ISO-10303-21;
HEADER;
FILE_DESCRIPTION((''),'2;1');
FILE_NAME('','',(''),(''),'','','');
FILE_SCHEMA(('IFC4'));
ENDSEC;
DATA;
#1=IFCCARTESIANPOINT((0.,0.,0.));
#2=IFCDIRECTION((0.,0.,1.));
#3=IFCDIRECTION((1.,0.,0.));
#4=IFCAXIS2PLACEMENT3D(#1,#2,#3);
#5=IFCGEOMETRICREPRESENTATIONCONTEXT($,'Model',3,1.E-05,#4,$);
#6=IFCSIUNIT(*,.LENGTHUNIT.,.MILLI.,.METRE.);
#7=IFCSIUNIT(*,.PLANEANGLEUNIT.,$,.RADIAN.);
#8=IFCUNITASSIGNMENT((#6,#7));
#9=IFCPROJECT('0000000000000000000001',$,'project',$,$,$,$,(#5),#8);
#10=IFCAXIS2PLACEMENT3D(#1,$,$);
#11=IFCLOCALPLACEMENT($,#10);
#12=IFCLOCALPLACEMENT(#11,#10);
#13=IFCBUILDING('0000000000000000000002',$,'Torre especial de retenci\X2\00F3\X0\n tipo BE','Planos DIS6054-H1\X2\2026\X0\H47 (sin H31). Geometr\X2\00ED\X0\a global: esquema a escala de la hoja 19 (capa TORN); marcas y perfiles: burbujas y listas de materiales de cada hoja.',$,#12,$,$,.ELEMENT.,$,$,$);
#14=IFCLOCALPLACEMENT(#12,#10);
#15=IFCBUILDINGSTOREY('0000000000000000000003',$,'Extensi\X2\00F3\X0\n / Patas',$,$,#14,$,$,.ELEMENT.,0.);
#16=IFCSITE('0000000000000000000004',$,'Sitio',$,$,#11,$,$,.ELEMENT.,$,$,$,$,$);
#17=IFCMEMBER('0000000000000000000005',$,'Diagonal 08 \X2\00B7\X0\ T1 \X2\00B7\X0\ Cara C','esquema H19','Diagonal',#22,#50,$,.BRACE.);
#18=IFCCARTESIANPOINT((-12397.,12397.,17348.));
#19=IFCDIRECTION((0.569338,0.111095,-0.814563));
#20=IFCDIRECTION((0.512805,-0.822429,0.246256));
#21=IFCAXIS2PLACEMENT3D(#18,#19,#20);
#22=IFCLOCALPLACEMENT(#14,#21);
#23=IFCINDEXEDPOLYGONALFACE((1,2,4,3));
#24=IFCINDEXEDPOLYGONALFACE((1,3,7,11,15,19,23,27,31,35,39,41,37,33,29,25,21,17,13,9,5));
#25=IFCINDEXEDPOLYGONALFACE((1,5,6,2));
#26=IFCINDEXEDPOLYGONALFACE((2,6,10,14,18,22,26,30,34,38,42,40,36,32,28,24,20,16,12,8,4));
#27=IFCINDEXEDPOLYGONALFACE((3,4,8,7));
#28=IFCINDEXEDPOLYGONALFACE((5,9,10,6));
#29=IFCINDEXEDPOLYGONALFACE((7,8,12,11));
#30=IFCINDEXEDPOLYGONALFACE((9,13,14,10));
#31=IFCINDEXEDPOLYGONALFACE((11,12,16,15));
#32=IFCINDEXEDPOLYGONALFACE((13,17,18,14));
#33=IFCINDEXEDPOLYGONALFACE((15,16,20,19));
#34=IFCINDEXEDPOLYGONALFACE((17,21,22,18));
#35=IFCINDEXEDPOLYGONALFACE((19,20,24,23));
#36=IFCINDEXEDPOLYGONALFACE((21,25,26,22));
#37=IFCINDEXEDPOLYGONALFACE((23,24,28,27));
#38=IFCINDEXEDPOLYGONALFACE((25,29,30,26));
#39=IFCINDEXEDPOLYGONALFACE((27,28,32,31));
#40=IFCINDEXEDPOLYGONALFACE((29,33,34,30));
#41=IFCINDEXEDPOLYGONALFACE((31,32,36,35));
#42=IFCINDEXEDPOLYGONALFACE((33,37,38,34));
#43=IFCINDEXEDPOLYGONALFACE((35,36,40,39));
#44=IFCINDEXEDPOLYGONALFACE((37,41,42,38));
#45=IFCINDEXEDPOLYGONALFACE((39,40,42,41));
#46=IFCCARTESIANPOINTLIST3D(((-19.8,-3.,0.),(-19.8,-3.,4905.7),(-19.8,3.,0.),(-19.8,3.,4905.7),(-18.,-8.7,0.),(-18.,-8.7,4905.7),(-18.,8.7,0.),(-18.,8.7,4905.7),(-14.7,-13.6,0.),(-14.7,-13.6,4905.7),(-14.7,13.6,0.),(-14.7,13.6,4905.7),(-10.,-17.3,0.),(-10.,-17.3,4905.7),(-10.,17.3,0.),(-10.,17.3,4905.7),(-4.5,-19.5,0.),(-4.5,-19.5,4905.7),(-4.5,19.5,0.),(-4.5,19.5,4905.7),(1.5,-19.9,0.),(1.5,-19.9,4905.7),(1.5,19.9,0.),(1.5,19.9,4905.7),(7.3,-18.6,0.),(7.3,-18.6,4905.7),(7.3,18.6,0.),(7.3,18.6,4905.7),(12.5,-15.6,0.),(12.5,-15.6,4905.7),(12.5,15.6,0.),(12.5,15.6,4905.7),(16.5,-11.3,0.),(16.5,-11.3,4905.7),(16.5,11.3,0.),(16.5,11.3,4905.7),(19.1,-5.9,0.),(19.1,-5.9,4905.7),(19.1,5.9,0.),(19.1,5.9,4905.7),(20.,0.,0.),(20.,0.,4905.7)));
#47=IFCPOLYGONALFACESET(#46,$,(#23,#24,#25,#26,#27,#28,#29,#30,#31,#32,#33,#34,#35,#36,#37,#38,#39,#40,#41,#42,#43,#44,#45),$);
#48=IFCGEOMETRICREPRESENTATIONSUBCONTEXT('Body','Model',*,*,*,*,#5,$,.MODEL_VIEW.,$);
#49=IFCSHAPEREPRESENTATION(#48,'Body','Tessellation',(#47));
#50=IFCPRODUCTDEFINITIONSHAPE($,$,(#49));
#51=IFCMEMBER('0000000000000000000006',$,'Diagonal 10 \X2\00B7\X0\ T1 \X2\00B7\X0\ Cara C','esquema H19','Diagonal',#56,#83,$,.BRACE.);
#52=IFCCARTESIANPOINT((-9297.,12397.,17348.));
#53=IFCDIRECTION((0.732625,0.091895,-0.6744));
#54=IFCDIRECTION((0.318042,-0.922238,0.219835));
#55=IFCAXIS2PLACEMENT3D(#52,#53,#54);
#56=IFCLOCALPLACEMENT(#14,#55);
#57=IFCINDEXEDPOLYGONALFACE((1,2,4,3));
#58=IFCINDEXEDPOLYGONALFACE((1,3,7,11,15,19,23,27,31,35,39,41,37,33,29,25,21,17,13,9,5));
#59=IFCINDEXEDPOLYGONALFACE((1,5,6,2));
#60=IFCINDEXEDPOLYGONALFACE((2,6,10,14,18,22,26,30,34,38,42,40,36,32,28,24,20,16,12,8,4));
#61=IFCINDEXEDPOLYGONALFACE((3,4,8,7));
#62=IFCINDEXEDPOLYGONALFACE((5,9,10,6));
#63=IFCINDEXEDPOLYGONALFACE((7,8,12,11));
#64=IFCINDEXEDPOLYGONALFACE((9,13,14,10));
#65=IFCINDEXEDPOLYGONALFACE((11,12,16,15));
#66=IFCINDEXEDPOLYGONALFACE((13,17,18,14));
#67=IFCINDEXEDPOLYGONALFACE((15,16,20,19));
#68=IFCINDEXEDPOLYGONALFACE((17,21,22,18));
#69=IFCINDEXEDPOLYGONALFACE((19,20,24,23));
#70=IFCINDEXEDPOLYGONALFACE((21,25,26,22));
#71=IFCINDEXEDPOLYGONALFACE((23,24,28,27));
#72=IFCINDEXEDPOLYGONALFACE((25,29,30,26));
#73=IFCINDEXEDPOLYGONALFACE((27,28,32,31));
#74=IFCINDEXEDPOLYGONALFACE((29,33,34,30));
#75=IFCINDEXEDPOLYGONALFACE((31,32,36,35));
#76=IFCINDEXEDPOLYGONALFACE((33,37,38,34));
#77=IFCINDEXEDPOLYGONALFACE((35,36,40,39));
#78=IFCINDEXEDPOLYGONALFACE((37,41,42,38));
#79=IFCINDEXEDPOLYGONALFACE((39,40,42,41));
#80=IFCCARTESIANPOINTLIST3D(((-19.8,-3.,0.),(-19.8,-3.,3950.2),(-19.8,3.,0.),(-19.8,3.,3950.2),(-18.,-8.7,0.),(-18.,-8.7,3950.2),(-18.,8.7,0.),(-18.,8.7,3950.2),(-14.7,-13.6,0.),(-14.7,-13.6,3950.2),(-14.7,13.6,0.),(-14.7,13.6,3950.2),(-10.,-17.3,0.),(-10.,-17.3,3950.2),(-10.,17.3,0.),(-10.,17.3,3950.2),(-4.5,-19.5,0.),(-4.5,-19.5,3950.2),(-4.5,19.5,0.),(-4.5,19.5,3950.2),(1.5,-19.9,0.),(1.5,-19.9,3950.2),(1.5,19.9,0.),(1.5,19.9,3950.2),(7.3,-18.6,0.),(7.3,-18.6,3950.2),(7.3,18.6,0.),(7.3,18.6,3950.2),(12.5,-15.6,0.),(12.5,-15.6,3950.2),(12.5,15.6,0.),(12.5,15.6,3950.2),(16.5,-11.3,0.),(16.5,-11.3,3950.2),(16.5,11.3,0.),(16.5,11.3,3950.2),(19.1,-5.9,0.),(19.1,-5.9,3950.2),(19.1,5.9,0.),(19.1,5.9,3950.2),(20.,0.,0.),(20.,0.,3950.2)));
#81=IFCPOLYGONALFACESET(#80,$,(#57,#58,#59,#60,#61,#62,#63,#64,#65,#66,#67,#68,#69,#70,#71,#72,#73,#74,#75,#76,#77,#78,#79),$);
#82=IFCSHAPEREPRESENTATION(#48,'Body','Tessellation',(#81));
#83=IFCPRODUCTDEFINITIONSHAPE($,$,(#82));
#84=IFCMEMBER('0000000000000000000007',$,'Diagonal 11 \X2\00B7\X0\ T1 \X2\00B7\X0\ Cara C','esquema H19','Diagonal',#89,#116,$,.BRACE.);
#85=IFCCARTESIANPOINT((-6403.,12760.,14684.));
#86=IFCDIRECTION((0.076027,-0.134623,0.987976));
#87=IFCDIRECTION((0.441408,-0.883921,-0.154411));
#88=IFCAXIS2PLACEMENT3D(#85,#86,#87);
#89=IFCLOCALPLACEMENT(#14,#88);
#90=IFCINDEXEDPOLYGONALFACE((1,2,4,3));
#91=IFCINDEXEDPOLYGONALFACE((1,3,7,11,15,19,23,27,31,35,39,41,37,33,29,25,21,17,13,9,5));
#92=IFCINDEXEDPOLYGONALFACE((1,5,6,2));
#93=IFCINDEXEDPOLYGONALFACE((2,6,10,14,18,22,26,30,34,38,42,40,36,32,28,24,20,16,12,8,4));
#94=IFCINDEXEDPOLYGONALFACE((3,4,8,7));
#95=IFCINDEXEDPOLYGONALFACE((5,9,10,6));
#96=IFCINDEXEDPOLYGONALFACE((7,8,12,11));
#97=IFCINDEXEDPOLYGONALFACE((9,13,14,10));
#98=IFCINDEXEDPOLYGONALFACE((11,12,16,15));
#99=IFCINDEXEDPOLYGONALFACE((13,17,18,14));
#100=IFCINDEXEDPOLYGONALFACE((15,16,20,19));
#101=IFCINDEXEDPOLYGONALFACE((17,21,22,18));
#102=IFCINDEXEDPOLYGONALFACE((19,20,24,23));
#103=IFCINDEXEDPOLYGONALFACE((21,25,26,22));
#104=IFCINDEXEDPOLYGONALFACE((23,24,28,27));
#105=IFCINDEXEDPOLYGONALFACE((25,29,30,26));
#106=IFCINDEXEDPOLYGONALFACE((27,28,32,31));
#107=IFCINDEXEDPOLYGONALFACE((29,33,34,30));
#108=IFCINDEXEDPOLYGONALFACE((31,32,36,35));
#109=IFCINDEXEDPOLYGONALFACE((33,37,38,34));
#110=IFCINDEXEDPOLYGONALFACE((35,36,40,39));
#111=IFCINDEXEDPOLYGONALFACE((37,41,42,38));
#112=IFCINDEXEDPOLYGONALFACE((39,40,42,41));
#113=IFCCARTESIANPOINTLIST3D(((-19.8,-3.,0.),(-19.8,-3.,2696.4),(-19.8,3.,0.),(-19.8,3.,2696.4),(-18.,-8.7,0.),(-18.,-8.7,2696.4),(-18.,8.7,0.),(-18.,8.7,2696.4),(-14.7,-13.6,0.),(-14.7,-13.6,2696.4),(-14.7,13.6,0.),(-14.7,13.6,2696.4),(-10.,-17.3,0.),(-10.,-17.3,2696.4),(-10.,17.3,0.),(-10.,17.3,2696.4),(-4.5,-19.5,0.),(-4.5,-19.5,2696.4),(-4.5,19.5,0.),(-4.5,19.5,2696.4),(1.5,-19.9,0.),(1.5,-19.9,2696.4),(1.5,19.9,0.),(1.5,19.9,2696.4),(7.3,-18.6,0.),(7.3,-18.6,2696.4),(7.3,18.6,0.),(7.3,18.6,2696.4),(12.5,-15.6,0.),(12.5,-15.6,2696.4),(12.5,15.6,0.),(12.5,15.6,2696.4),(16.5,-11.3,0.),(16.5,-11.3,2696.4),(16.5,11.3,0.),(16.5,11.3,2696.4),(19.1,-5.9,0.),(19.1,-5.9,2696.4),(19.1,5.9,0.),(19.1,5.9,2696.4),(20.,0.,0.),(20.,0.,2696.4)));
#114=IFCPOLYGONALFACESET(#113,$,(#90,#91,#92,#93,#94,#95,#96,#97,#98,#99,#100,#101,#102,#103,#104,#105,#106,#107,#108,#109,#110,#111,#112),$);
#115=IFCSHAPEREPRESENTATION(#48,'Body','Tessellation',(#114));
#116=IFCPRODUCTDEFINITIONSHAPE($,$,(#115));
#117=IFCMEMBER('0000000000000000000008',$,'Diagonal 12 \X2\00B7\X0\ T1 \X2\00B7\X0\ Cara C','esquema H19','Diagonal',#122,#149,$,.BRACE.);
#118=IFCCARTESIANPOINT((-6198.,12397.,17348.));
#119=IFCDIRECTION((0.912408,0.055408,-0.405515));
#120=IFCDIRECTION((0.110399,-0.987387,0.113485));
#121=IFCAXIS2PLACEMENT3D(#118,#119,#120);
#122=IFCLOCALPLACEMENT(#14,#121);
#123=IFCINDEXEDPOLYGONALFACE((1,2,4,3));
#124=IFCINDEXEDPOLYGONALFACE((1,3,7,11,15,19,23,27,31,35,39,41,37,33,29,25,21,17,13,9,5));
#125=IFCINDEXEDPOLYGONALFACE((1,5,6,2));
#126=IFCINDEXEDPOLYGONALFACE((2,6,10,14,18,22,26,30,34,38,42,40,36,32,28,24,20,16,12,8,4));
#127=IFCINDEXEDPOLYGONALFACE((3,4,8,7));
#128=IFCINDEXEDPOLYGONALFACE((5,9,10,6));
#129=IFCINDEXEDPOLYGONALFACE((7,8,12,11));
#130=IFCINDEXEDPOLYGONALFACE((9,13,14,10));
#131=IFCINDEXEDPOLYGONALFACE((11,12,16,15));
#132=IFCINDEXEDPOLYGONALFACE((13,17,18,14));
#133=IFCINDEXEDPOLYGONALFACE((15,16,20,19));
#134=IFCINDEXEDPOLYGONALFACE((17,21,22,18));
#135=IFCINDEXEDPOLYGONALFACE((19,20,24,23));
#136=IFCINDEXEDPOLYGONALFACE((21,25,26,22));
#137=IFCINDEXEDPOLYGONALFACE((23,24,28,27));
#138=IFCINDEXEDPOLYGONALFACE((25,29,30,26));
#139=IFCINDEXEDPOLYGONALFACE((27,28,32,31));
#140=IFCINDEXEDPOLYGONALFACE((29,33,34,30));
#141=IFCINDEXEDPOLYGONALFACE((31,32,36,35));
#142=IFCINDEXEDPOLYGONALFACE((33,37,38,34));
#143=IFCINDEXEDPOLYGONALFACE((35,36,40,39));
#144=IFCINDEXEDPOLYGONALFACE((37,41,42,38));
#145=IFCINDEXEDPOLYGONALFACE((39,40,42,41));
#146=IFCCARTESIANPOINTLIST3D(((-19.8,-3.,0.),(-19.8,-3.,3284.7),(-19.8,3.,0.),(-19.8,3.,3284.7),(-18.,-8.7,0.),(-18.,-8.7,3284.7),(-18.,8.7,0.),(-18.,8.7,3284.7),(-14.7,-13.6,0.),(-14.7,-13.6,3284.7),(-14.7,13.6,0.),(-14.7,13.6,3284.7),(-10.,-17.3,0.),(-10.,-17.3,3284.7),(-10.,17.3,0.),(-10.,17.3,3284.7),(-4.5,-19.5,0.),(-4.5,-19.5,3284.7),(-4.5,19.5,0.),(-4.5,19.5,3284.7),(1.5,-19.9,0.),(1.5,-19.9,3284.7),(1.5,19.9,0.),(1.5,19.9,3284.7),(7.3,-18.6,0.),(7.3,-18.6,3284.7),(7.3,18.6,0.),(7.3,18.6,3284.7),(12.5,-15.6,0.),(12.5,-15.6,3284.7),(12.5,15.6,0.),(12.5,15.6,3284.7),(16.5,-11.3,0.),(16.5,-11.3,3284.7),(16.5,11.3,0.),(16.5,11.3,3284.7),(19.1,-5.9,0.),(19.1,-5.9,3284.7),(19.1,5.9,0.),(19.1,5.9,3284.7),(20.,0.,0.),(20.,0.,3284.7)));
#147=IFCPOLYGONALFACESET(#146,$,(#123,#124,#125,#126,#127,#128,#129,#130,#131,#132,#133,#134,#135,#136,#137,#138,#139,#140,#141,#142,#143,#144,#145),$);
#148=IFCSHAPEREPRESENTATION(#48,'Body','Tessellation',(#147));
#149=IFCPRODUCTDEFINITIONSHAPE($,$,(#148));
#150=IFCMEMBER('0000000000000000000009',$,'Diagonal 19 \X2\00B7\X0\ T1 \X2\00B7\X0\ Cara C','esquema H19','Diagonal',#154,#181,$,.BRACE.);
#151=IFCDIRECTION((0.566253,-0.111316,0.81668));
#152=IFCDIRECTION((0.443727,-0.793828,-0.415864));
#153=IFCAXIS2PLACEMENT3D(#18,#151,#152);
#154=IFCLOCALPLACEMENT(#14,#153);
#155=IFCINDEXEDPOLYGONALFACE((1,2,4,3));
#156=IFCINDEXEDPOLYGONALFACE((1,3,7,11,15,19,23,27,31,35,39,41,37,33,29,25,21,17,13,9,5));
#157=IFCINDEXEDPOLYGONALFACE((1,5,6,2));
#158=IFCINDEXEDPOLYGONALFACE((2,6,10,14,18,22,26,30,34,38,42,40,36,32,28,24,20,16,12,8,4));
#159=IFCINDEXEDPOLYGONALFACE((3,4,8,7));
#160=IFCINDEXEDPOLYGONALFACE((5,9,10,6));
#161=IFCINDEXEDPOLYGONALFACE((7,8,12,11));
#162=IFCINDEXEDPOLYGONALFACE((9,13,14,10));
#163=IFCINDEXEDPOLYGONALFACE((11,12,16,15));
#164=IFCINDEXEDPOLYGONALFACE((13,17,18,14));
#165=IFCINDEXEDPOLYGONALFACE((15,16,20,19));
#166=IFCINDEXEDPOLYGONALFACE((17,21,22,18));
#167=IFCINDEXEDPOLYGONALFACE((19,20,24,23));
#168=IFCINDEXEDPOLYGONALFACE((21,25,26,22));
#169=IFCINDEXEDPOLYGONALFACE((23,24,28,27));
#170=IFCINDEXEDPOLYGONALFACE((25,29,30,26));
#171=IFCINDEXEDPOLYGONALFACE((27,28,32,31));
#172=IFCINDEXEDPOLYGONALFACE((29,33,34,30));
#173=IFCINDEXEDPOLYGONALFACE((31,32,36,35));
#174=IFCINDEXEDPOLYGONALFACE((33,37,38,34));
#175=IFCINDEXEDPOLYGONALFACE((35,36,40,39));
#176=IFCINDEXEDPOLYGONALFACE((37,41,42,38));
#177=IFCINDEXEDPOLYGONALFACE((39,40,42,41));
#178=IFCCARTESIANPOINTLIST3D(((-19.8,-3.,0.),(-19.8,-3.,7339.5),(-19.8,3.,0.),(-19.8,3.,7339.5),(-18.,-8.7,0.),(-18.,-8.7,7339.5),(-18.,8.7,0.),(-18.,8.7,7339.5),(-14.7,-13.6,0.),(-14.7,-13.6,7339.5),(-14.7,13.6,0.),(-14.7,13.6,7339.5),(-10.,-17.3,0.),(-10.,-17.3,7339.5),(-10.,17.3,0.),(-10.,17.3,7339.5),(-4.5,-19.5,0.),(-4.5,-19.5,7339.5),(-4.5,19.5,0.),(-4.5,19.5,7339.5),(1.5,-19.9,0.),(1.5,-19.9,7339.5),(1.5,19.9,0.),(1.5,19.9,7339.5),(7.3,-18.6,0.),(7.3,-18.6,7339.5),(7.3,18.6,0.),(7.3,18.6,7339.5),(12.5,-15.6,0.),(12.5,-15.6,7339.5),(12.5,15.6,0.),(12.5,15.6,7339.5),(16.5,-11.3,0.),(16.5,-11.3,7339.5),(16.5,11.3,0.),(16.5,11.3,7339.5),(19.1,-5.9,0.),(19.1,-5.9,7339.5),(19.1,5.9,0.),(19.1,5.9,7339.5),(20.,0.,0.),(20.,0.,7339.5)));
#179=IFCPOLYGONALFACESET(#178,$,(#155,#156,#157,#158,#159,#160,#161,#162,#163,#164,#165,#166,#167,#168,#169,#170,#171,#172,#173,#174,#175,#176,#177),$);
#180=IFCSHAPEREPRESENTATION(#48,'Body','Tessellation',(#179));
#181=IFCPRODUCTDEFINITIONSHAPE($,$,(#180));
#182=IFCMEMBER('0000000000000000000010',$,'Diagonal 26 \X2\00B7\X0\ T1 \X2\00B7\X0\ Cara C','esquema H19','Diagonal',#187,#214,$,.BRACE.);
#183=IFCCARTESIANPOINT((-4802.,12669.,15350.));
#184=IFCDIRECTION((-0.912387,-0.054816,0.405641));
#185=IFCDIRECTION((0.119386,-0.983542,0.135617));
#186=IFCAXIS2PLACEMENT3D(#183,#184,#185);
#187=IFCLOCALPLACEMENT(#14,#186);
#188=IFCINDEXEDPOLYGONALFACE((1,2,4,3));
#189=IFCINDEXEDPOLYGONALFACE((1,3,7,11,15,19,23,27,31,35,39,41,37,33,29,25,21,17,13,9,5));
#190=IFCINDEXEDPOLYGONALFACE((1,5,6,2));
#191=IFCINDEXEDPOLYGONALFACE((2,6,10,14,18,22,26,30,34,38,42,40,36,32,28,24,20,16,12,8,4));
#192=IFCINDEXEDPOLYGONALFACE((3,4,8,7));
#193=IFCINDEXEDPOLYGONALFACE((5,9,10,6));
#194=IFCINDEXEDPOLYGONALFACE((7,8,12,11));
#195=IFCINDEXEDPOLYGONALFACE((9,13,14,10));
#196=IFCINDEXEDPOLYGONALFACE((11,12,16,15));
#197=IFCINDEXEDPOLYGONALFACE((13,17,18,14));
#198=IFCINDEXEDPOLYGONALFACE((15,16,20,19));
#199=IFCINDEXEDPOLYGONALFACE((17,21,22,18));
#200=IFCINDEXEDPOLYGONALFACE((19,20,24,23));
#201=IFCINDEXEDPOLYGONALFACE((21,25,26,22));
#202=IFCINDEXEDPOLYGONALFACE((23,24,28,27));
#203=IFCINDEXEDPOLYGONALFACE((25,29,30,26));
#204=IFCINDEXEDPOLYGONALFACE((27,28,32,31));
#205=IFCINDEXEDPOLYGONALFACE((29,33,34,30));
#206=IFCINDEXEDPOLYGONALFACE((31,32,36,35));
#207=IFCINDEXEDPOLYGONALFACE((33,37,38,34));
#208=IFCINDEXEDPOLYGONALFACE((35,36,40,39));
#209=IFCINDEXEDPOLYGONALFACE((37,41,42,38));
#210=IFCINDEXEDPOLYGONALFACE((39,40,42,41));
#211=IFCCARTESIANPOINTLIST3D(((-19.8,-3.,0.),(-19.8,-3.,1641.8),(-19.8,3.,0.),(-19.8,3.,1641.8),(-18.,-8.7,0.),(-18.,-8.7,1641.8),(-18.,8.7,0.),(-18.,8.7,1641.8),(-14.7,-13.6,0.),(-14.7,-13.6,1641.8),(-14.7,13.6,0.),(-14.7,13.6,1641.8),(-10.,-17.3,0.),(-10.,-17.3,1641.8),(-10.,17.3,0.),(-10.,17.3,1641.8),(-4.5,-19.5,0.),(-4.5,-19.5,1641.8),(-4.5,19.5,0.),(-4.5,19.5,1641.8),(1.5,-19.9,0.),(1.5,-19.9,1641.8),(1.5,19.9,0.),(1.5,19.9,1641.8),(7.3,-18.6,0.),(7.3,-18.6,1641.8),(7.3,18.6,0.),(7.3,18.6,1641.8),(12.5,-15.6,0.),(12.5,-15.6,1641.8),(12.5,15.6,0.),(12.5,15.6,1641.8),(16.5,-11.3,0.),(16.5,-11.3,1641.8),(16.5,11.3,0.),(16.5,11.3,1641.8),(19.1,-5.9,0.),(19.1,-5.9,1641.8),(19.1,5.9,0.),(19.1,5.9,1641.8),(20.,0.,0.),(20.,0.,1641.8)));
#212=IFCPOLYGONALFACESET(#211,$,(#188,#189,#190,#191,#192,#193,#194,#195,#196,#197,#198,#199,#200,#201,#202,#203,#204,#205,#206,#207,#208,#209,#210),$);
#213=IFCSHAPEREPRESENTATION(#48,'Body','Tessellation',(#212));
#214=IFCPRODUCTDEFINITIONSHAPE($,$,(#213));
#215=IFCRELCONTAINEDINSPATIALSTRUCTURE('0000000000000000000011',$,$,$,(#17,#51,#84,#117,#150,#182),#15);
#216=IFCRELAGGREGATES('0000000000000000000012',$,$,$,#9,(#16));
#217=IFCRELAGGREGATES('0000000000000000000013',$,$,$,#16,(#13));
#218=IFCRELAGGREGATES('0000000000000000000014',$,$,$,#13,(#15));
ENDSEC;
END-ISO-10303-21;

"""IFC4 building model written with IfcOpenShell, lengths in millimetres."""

from ifc_helpers import new_model, si_unit, frame, origin, origin_with_axes, place, context, subcontext, project, spatial, circle, extrude, element, save


model = new_model("IFC4")

# Units and contexts
model_context = context("Model", 3, precision=1e-05, world=origin_with_axes())
body_context = subcontext(model_context, "Body", "Model", "MODEL_VIEW")
ifc_project = project(units=[si_unit("LENGTHUNIT", "METRE", prefix="MILLI"), si_unit("PLANEANGLEUNIT", "RADIAN")], contexts=[model_context])

# Site, building, storey
site_placement = place(None, origin())
site = spatial("IfcSite", under=ifc_project, at=site_placement, Name="Sitio", CompositionType="ELEMENT")
building_placement = place(site_placement, origin())
building = spatial("IfcBuilding", under=site, at=building_placement, Name="Torre especial de retención tipo BE", Description="Planos DIS6054-H1…H47 (sin H31). Geometría global: esquema a escala de la hoja 19 (capa TORN); marcas y perfiles: burbujas y listas de materiales de cada hoja.", CompositionType="ELEMENT")
storey_placement = place(building_placement, origin())
storey = spatial("IfcBuildingStorey", under=building, at=storey_placement, Name="Extensión / Patas", CompositionType="ELEMENT", Elevation=0.0)

# Members
member_1_placement = place(storey_placement, frame((-12397.0, 12397.0, 17348.0), z_axis=(0.569338, 0.111095, -0.814563), x_axis=(0.512805, -0.822429, 0.246256)))
element("IfcMember", 1, at=member_1_placement, inside=storey, Name="Diagonal 08 · T1 · Cara C", Description="esquema H19", ObjectType="Diagonal", PredefinedType="BRACE", context=body_context, shape_type="SweptSolid", body=[
    extrude(circle(Radius=20.0), None, (0.0, 0.0, 1.0), 4905.7),
])
member_2_placement = place(storey_placement, frame((-9297.0, 12397.0, 17348.0), z_axis=(0.732625, 0.091895, -0.6744), x_axis=(0.318042, -0.922238, 0.219835)))
element("IfcMember", 2, at=member_2_placement, inside=storey, Name="Diagonal 10 · T1 · Cara C", Description="esquema H19", ObjectType="Diagonal", PredefinedType="BRACE", context=body_context, shape_type="SweptSolid", body=[
    extrude(circle(Radius=20.0), None, (0.0, 0.0, 1.0), 3950.2),
])
member_3_placement = place(storey_placement, frame((-6403.0, 12760.0, 14684.0), z_axis=(0.076027, -0.134623, 0.987976), x_axis=(0.441408, -0.883921, -0.154411)))
element("IfcMember", 3, at=member_3_placement, inside=storey, Name="Diagonal 11 · T1 · Cara C", Description="esquema H19", ObjectType="Diagonal", PredefinedType="BRACE", context=body_context, shape_type="SweptSolid", body=[
    extrude(circle(Radius=20.0), None, (0.0, 0.0, 1.0), 2696.4),
])
member_4_placement = place(storey_placement, frame((-6198.0, 12397.0, 17348.0), z_axis=(0.912408, 0.055408, -0.405515), x_axis=(0.110399, -0.987387, 0.113485)))
element("IfcMember", 4, at=member_4_placement, inside=storey, Name="Diagonal 12 · T1 · Cara C", Description="esquema H19", ObjectType="Diagonal", PredefinedType="BRACE", context=body_context, shape_type="SweptSolid", body=[
    extrude(circle(Radius=20.0), None, (0.0, 0.0, 1.0), 3284.7),
])
member_5_placement = place(storey_placement, frame((-12397.0, 12397.0, 17348.0), z_axis=(0.566253, -0.111316, 0.81668), x_axis=(0.443727, -0.793828, -0.415864)))
element("IfcMember", 5, at=member_5_placement, inside=storey, Name="Diagonal 19 · T1 · Cara C", Description="esquema H19", ObjectType="Diagonal", PredefinedType="BRACE", context=body_context, shape_type="SweptSolid", body=[
    extrude(circle(Radius=20.0), None, (0.0, 0.0, 1.0), 7339.5),
])
member_6_placement = place(storey_placement, frame((-4802.0, 12669.0, 15350.0), z_axis=(-0.912387, -0.054816, 0.405641), x_axis=(0.119386, -0.983542, 0.135617)))
element("IfcMember", 6, at=member_6_placement, inside=storey, Name="Diagonal 26 · T1 · Cara C", Description="esquema H19", ObjectType="Diagonal", PredefinedType="BRACE", context=body_context, shape_type="SweptSolid", body=[
    extrude(circle(Radius=20.0), None, (0.0, 0.0, 1.0), 1641.8),
])

save(model, "model.ifc")
